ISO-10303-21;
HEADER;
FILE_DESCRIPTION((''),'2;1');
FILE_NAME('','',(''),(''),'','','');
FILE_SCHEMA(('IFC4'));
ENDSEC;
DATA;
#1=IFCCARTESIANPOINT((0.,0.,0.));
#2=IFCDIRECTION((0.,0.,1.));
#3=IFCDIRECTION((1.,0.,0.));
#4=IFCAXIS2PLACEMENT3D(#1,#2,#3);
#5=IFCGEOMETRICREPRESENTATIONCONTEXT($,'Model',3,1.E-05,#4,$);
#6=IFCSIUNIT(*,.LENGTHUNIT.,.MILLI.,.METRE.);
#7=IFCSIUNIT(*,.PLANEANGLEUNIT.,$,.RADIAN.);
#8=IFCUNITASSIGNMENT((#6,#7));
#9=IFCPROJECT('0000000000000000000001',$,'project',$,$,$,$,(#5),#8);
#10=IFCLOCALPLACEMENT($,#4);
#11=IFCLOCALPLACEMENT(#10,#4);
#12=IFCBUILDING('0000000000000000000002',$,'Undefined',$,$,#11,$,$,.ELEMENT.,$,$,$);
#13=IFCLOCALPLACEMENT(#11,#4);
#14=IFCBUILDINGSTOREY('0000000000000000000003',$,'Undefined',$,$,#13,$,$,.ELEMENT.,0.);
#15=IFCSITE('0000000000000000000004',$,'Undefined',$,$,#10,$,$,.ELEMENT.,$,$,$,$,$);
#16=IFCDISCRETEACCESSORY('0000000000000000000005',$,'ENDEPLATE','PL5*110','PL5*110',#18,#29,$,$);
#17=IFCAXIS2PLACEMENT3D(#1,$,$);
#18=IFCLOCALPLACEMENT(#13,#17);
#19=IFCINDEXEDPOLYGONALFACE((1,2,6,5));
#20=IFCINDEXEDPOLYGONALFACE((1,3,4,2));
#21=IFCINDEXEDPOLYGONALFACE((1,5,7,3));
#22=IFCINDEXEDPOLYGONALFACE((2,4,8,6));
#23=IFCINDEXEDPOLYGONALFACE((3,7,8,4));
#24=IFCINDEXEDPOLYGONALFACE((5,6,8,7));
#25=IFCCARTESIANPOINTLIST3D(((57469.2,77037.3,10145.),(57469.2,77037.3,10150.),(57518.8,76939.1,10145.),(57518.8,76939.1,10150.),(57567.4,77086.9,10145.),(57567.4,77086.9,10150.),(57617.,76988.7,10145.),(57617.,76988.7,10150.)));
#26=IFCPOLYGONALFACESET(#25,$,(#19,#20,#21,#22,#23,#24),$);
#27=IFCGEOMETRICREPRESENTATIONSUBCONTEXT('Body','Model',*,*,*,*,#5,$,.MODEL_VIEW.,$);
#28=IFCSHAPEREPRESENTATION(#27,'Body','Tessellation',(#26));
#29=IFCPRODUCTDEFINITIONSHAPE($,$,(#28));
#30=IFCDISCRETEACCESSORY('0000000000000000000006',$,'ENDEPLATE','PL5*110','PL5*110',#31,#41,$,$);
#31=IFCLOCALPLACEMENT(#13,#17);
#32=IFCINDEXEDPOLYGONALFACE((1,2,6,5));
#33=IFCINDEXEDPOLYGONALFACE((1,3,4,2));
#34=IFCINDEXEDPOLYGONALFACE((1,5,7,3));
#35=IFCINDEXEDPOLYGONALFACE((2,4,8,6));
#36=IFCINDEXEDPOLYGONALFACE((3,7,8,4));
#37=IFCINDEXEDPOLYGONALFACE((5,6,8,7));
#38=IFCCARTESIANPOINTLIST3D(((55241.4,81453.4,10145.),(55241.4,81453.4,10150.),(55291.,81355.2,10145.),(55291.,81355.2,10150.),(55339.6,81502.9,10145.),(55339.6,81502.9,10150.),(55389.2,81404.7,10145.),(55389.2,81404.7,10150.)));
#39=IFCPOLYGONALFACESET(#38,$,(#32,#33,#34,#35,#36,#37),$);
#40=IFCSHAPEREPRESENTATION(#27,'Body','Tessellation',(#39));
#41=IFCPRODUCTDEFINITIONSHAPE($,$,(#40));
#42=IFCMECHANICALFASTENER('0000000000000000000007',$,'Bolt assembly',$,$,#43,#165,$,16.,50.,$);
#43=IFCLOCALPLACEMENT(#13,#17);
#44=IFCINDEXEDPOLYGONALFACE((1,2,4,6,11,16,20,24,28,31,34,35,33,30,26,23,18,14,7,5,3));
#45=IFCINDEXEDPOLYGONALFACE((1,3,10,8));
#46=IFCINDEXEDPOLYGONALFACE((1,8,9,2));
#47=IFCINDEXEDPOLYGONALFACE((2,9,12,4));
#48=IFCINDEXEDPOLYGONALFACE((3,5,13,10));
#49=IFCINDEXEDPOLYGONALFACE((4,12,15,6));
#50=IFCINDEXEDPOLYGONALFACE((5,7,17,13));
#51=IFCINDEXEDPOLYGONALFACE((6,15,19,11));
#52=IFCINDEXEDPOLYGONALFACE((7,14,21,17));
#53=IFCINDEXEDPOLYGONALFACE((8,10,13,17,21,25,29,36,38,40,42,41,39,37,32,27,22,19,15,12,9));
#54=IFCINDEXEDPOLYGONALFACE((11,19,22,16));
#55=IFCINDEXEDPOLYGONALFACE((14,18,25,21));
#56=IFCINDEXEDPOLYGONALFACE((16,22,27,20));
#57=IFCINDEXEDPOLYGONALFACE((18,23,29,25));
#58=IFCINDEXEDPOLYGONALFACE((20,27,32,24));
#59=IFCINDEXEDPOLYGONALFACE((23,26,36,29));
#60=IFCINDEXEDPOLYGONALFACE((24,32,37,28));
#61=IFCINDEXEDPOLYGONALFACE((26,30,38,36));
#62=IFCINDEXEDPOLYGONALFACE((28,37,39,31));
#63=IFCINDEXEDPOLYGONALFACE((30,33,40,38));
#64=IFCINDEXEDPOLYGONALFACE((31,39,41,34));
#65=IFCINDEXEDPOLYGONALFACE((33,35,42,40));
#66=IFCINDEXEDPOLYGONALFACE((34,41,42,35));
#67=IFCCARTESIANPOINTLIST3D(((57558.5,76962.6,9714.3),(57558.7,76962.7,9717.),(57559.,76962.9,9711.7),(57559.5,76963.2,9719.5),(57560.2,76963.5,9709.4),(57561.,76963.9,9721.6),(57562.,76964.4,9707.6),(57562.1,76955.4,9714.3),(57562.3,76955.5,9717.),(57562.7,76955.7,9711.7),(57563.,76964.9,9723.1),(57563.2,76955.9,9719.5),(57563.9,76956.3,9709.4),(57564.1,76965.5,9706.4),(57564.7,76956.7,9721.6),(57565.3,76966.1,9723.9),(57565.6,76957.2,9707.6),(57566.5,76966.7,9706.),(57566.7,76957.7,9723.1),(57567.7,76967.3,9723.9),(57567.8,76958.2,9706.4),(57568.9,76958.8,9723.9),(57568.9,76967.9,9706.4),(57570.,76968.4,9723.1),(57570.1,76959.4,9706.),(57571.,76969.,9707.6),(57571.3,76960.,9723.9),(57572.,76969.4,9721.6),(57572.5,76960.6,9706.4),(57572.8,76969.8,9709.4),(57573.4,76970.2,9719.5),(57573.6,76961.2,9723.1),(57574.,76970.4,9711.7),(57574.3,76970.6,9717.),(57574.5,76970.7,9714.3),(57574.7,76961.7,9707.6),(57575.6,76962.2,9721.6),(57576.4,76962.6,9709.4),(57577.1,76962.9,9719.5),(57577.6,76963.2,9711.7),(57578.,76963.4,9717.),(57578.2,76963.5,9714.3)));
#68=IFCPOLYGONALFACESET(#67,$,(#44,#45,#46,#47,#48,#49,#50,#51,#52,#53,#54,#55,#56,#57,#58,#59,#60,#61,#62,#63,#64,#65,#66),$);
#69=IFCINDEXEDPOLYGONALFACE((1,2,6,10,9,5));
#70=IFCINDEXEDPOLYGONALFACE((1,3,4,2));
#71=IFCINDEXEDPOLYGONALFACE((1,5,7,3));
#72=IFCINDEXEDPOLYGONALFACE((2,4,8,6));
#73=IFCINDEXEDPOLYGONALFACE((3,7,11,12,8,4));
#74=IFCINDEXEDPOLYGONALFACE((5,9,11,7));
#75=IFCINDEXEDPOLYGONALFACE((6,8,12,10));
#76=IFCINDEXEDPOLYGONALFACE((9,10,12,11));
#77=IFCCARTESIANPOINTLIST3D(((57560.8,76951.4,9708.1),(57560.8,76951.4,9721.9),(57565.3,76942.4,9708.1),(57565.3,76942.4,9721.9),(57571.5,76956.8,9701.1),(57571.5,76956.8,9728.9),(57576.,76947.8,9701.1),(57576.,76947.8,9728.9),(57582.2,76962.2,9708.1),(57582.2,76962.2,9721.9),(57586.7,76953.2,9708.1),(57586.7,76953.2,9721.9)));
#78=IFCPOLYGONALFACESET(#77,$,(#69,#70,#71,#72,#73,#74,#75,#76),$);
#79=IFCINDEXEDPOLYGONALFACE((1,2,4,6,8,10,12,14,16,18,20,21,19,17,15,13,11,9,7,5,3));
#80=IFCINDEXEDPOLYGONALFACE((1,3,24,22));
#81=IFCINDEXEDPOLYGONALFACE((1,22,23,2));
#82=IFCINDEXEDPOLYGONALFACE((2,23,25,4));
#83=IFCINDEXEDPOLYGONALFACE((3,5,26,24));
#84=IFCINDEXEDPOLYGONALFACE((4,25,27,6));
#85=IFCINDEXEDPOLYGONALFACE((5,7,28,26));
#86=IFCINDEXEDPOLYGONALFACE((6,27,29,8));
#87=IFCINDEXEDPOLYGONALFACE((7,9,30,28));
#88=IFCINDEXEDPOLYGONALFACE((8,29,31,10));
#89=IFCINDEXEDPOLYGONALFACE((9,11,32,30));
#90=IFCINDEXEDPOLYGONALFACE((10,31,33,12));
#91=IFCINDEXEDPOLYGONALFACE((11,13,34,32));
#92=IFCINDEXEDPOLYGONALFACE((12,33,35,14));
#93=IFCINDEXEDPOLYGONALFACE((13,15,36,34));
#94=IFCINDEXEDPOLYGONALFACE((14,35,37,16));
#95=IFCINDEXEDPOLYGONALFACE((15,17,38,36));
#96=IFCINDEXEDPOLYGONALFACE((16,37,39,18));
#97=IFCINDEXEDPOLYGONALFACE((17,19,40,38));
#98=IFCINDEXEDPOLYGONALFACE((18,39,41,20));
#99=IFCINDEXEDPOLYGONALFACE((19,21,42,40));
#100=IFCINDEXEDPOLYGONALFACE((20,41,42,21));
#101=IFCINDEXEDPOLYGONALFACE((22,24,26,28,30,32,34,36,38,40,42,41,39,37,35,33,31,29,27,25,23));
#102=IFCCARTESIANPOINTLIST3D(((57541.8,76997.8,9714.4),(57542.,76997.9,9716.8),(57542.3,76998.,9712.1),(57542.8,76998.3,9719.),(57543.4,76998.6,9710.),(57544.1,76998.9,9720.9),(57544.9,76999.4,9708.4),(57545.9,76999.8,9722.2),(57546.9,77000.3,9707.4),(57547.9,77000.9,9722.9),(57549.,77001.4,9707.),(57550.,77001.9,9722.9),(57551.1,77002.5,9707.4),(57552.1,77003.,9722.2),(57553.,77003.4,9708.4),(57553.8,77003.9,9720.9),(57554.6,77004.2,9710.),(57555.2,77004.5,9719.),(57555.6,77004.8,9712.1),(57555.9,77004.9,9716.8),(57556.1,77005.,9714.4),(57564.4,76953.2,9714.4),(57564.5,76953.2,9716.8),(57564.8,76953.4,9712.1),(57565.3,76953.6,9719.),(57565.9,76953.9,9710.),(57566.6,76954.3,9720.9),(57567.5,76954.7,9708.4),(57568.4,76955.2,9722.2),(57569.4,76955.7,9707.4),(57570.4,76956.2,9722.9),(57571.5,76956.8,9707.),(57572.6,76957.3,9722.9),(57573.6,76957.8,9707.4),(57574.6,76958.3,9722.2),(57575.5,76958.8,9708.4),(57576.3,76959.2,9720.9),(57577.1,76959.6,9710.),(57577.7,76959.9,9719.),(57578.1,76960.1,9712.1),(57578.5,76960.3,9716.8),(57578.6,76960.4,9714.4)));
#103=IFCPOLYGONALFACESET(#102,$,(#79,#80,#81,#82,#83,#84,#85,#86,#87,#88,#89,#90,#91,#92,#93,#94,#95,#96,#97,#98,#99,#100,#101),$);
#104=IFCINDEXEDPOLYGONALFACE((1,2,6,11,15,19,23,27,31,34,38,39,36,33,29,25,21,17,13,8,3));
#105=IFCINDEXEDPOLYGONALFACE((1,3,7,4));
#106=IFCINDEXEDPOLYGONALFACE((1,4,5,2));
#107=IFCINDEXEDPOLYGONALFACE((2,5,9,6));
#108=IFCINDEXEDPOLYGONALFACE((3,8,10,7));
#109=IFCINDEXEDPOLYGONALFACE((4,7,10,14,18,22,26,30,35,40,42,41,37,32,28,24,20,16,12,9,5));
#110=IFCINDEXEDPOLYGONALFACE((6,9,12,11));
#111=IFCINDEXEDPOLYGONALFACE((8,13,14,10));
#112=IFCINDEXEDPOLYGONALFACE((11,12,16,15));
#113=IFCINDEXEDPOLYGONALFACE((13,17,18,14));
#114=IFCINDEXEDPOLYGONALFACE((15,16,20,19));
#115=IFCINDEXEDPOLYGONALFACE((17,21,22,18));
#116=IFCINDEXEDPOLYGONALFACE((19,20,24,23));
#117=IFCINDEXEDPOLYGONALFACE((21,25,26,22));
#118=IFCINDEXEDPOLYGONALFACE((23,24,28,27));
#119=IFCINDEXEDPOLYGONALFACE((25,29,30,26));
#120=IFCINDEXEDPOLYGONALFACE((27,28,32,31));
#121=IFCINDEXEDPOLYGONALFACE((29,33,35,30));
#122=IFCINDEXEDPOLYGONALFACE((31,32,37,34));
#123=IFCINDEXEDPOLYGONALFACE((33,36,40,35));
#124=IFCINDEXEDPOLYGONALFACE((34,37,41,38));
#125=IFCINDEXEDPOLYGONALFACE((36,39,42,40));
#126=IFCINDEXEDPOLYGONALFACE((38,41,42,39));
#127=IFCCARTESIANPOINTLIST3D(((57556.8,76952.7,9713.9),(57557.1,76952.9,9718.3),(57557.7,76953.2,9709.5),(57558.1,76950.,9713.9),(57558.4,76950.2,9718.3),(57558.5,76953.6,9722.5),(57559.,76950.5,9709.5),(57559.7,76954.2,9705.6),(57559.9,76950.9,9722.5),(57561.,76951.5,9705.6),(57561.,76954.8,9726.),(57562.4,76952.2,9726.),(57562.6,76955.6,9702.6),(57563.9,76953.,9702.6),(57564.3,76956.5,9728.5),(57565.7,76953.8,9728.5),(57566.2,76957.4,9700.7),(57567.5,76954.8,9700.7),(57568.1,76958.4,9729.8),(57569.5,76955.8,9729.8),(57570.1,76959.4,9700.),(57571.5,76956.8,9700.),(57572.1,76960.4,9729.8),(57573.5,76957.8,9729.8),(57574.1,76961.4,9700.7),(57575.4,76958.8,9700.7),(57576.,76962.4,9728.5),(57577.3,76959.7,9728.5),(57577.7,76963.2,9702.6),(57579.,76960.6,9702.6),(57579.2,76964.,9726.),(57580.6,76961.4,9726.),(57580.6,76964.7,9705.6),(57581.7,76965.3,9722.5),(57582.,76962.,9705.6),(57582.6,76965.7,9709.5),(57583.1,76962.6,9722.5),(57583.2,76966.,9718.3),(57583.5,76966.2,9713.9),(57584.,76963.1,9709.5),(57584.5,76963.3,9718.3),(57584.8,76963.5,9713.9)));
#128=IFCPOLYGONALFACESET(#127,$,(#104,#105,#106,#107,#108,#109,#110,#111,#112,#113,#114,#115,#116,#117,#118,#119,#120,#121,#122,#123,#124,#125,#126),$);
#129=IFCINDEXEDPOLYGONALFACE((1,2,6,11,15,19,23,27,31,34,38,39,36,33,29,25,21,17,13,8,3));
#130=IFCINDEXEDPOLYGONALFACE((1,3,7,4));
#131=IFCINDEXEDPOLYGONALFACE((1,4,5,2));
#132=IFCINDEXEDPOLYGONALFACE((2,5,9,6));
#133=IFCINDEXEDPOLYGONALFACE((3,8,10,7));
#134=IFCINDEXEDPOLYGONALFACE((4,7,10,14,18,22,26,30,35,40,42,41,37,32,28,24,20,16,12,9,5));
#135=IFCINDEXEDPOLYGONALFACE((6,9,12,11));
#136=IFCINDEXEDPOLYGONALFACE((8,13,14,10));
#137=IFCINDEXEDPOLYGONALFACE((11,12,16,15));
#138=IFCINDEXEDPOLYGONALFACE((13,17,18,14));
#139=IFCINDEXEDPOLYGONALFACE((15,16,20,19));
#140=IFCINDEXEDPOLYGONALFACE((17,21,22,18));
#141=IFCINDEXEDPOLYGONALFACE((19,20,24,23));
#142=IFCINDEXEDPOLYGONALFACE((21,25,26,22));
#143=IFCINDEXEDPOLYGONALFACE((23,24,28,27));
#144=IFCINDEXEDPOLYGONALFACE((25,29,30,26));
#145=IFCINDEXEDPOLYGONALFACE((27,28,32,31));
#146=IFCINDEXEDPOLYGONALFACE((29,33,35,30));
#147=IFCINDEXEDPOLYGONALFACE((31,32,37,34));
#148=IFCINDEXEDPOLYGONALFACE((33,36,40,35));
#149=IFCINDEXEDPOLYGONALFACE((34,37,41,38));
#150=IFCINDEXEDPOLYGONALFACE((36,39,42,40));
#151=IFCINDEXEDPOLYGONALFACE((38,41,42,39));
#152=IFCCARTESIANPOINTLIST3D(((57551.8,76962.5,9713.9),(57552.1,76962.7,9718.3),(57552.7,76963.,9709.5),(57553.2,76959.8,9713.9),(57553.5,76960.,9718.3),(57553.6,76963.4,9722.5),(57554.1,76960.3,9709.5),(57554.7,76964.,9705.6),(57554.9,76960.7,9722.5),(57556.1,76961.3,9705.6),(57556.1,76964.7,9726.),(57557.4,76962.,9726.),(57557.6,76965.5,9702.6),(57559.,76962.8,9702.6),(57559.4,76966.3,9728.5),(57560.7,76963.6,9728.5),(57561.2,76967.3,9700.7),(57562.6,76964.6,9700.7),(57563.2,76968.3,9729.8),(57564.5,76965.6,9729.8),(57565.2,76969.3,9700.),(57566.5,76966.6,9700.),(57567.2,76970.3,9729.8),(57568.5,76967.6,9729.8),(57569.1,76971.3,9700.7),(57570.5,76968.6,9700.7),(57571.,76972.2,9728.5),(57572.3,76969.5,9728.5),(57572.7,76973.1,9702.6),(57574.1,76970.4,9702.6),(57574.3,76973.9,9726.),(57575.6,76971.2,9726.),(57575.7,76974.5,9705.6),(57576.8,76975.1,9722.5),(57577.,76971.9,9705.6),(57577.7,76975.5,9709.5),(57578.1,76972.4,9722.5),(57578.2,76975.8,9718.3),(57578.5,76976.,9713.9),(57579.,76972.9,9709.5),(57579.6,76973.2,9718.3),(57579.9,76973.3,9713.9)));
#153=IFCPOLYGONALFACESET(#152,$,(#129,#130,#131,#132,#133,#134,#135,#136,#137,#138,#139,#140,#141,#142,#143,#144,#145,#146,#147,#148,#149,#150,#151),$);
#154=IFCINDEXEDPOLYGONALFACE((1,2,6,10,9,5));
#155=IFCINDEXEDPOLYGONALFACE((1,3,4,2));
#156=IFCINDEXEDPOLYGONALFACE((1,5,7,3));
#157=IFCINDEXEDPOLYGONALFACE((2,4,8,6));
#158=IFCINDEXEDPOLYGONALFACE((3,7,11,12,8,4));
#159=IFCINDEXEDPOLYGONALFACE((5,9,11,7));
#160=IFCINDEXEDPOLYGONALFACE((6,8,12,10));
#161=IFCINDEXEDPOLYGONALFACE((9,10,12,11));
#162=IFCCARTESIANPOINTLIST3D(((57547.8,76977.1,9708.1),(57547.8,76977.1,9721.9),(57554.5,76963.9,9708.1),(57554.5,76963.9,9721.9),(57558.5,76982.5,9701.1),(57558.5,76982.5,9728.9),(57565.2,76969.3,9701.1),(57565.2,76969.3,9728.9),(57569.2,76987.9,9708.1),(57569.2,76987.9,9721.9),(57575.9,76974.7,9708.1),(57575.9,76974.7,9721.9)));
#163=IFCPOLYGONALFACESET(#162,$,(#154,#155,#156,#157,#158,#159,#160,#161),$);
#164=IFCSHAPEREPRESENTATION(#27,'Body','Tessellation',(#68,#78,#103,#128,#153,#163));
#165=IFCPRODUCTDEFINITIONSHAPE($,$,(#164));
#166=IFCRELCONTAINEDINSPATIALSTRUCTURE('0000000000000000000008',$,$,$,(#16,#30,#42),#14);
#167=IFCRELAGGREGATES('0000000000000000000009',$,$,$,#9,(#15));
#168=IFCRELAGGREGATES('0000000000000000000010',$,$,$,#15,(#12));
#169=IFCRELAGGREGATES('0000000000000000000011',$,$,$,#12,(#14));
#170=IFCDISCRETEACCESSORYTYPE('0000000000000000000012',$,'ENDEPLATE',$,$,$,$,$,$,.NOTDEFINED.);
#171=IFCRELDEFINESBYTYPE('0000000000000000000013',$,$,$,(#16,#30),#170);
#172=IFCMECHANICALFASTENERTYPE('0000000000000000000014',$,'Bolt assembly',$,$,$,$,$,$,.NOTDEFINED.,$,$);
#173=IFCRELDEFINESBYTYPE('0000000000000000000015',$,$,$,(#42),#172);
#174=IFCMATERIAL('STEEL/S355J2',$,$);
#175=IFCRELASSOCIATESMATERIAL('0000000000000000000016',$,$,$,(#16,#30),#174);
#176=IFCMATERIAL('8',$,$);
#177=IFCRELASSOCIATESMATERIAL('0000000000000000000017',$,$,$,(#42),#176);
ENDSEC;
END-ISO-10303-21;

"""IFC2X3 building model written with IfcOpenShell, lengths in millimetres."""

from ifc_helpers import new_model, si_unit, frame, origin_with_axes, origin_2d_with_axis, place, context, subcontext, project, spatial, polyline, circle, outline, extrude, source, transform, mapped, material, type_object, element, save


model = new_model("IFC2X3")

# Units and contexts
model_context = context("Model", 3, precision=1e-05, world=origin_with_axes())
body_context = subcontext(model_context, "Body", "Model", "MODEL_VIEW")
ifc_project = project(units=[si_unit("LENGTHUNIT", "METRE", prefix="MILLI"), si_unit("PLANEANGLEUNIT", "RADIAN")], contexts=[model_context])

# Site, building, storey
site_placement = place(None, origin_with_axes())
site = spatial("IfcSite", under=ifc_project, at=site_placement, Name="Undefined", CompositionType="ELEMENT")
building_placement = place(site_placement, origin_with_axes())
building = spatial("IfcBuilding", under=site, at=building_placement, Name="Undefined", CompositionType="ELEMENT")
storey_placement = place(building_placement, origin_with_axes())
storey = spatial("IfcBuildingStorey", under=building, at=storey_placement, Name="Undefined", CompositionType="ELEMENT", Elevation=0.0)

# Shared definitions
ifc_material_1 = material(Name="STEEL/S355J2")

# Discrete accessories
discrete_accessory_type = type_object("IfcDiscreteAccessoryType", Name="ENDEPLATE")
discrete_accessory_1_placement = place(storey_placement, frame((57518.3, 77062.1, 10147.5), z_axis=(0.0, 0.0, -1.0), x_axis=(0.450512, -0.89277, 0.0)))
element("IfcDiscreteAccessory", 1, at=discrete_accessory_1_placement, inside=storey, type_object=discrete_accessory_type, material=ifc_material_1, Name="ENDEPLATE", Description="PL5*110", ObjectType="PL5*110", context=body_context, shape_type="SweptSolid", body=[
    extrude(outline(polyline([(0.0, 55.0), (110.0, 55.0), (110.0, -55.0), (0.0, -55.0), (0.0, 55.0)])), frame((0.0, 0.0, -2.5), z_axis=(0.0, 0.0, 1.0), x_axis=(1.0, 0.0, 0.0)), (0.0, 0.0, 1.0), 5.0),
])
discrete_accessory_2_placement = place(storey_placement, frame((55340.1, 81379.9, 10147.5), z_axis=(0.0, 0.0, -1.0), x_axis=(-0.450512, 0.89277, 0.0)))
element("IfcDiscreteAccessory", 2, at=discrete_accessory_2_placement, inside=storey, type_object=discrete_accessory_type, material=ifc_material_1, Name="ENDEPLATE", Description="PL5*110", ObjectType="PL5*110", context=body_context, shape_type="SweptSolid", body=[
    extrude(outline(polyline([(110.0, -55.0), (0.0, -55.0), (0.0, 55.0), (110.0, 55.0), (110.0, -55.0)])), frame((0.0, 0.0, -2.5), z_axis=(0.0, 0.0, 1.0), x_axis=(1.0, 0.0, 0.0)), (0.0, 0.0, 1.0), 5.0),
])

# Mechanical fastener
ifc_material_2 = material(Name="8")
mechanical_fastener_type = type_object("IfcMechanicalFastenerType", Name="Bolt assembly")
shared_shape_1 = source(origin_with_axes(), body_context, "Body", "SweptSolid", [
    extrude(circle(Radius=9.0, at=origin_2d_with_axis()), frame((0.0, 0.0, 0.0), z_axis=(0.0, 1.0, 0.0), x_axis=(1.0, 0.0, 0.0)), (0.0, 0.0, 1.0), 8.1),
    extrude(outline(polyline([(13.9, 0.0), (6.9, 12.0), (-6.9, 12.0), (-13.9, 0.0), (-6.9, -12.0), (6.9, -12.0), (13.9, 0.0)])), frame((0.0, -13.0, 0.0), z_axis=(0.0, 1.0, 0.0), x_axis=(1.0, 0.0, 0.0)), (0.0, 0.0, 1.0), 10.0),
    extrude(circle(Radius=8.0, at=origin_2d_with_axis()), frame((0.0, -3.0, 0.0), z_axis=(0.0, 1.0, 0.0), x_axis=(1.0, 0.0, 0.0)), (0.0, 0.0, 1.0), 50.0),
    extrude(circle(Radius=15.0, at=origin_2d_with_axis()), frame((0.0, -3.0, 0.0), z_axis=(0.0, 1.0, 0.0), x_axis=(1.0, 0.0, 0.0)), (0.0, 0.0, 1.0), 3.0),
    extrude(circle(Radius=15.0, at=origin_2d_with_axis()), frame((0.0, 8.0, 0.0), z_axis=(0.0, 1.0, 0.0), x_axis=(1.0, 0.0, 0.0)), (0.0, 0.0, 1.0), 3.0),
    extrude(outline(polyline([(13.9, 0.0), (6.9, 12.0), (-6.9, 12.0), (-13.9, 0.0), (-6.9, -12.0), (6.9, -12.0), (13.9, 0.0)])), frame((0.0, 11.0, 0.0), z_axis=(0.0, 1.0, 0.0), x_axis=(1.0, 0.0, 0.0)), (0.0, 0.0, 1.0), 14.8),
])
mechanical_fastener_1_placement = place(storey_placement, frame((57570.1, 76959.4, 9715.0), z_axis=(0.892821, 0.450411, 0.0), x_axis=(-0.000057, 0.000114, -1.0)))
element("IfcMechanicalFastener", 3, at=mechanical_fastener_1_placement, inside=storey, type_object=mechanical_fastener_type, material=ifc_material_2, Name="Bolt assembly", NominalDiameter=16.0, NominalLength=50.0, context=body_context, shape_type="MappedRepresentation", body=[
    mapped(shared_shape_1, transform((0.0, 0.0, 0.0))),
])

save(model, "model.ifc")
